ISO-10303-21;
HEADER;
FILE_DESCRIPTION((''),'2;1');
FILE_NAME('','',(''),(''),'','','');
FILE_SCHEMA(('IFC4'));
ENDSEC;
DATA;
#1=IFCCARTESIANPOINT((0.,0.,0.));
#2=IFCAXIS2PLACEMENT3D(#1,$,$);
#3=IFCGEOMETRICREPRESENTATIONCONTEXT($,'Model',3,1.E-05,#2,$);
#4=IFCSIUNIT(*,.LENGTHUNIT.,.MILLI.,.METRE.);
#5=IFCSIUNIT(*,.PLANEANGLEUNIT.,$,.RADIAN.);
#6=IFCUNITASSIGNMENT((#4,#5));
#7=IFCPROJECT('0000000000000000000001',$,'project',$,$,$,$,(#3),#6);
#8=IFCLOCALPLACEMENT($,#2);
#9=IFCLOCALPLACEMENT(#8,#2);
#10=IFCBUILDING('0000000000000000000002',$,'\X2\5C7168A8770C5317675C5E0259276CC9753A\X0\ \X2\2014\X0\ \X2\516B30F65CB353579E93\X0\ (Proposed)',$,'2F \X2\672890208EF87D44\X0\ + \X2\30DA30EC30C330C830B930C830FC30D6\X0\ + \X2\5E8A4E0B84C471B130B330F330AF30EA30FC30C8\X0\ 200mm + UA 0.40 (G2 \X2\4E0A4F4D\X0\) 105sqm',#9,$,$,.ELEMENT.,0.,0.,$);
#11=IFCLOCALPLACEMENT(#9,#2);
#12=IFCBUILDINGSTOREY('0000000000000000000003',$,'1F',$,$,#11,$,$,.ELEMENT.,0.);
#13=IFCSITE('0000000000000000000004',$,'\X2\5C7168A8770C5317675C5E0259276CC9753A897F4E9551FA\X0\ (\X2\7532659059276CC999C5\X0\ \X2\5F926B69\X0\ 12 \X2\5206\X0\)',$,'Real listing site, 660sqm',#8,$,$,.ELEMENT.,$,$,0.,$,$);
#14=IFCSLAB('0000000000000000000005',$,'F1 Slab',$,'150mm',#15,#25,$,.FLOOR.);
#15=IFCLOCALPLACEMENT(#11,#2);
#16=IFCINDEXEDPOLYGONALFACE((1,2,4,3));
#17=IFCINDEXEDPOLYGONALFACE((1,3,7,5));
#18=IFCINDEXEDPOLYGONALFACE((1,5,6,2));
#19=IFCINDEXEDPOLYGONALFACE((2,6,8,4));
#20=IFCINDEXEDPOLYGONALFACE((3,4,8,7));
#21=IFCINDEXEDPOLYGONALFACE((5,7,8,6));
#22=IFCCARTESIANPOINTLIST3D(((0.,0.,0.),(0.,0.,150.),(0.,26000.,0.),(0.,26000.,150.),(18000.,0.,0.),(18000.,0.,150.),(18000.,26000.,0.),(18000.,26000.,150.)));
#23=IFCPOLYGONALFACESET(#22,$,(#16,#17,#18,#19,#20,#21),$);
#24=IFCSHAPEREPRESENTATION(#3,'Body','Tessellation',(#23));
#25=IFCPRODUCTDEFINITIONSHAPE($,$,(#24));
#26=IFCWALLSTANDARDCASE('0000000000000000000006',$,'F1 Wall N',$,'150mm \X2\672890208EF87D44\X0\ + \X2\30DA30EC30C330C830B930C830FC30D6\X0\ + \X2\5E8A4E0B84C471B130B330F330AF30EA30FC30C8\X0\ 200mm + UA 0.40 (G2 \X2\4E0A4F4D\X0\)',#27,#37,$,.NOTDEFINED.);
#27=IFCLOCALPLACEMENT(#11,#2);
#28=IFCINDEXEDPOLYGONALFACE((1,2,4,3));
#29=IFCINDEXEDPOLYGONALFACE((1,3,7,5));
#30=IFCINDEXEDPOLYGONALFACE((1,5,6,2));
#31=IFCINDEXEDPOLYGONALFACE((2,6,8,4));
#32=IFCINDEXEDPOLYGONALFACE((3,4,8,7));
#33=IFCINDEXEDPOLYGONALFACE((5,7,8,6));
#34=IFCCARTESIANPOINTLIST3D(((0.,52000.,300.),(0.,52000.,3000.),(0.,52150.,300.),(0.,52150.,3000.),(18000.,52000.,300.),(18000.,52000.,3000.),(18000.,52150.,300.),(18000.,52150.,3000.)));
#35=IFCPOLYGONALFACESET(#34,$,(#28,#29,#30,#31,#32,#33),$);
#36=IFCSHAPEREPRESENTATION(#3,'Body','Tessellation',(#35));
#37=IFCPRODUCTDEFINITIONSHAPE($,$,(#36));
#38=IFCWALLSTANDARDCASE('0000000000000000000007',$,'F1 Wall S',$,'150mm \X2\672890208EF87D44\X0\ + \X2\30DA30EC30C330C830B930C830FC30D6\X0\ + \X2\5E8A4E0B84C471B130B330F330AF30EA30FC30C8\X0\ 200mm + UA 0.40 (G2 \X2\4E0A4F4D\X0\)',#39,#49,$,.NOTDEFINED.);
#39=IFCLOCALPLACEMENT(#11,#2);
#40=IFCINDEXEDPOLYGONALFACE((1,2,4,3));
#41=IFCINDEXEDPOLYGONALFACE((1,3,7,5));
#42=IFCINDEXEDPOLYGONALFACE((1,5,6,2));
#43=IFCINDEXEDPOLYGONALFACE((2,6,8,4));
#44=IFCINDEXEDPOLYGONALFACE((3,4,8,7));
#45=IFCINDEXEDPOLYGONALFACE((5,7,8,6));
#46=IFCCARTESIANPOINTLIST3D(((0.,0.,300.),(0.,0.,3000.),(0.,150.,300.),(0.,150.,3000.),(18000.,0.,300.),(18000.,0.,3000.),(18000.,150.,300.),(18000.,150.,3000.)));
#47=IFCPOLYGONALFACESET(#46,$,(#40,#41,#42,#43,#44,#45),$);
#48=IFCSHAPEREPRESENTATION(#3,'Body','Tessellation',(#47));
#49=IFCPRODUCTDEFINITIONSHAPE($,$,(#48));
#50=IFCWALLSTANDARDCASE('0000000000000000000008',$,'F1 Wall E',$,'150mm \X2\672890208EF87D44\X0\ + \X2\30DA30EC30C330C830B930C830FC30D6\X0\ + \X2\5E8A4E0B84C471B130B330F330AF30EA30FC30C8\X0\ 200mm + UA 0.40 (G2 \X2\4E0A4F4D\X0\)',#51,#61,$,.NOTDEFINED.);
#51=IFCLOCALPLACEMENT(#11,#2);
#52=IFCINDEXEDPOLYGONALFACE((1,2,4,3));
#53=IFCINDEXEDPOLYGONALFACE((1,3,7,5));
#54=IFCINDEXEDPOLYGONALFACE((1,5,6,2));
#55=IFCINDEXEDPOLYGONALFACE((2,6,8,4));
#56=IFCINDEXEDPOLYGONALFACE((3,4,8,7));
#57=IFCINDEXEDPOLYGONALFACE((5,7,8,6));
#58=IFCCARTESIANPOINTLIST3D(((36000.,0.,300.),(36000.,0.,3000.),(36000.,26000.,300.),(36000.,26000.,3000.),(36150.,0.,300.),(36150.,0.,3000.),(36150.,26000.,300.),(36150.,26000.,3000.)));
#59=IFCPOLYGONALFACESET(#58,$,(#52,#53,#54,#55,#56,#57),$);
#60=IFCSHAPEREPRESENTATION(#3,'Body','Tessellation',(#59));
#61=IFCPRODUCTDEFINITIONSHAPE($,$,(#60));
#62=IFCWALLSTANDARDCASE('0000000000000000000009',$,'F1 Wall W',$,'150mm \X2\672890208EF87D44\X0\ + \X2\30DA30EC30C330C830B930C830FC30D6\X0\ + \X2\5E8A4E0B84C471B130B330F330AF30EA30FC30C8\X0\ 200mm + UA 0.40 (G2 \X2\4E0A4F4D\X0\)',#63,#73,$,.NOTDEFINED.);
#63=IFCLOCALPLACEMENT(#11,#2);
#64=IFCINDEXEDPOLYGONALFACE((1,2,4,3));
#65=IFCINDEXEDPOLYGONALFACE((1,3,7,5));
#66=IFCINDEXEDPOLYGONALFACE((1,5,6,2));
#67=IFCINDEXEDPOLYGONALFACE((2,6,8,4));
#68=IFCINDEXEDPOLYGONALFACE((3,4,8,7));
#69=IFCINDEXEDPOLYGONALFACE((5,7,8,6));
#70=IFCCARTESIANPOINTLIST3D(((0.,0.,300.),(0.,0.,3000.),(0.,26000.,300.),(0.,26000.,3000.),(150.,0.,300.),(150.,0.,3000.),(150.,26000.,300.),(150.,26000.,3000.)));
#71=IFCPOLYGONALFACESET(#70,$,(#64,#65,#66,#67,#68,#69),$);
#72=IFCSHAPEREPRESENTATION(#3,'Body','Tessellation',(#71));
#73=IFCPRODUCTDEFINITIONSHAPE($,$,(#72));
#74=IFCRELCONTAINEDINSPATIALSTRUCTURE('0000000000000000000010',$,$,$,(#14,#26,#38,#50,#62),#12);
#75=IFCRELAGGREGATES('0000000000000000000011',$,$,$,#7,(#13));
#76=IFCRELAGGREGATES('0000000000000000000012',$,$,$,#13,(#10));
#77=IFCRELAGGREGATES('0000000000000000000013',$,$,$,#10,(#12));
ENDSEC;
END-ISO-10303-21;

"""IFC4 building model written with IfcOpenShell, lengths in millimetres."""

from ifc_helpers import new_model, si_unit, frame, frame_2d, origin, place, context, project, spatial, rectangle, extrude, element, save


model = new_model("IFC4")

# Units and contexts
model_context = context("Model", 3, precision=1e-05, world=origin())
ifc_project = project(units=[si_unit("LENGTHUNIT", "METRE", prefix="MILLI"), si_unit("PLANEANGLEUNIT", "RADIAN")], contexts=[model_context])

# Site, building, storey
site_placement = place(None, origin())
site = spatial("IfcSite", under=ifc_project, at=site_placement, Name="山梨県北杜市大泉町西井出 (甲斐大泉駅 徒歩 12 分)", ObjectType="Real listing site, 660sqm", CompositionType="ELEMENT", RefElevation=0.0)
building_placement = place(site_placement, origin())
building = spatial("IfcBuilding", under=site, at=building_placement, Name="山梨県北杜市大泉町 — 八ヶ岳南麓 (Proposed)", ObjectType="2F 木造軸組 + ペレットストーブ + 床下蓄熱コンクリート 200mm + UA 0.40 (G2 上位) 105sqm", CompositionType="ELEMENT", ElevationOfRefHeight=0.0, ElevationOfTerrain=0.0)
storey_placement = place(building_placement, origin())
storey = spatial("IfcBuildingStorey", under=building, at=storey_placement, Name="1F", CompositionType="ELEMENT", Elevation=0.0)

# Slab
slab_placement = place(storey_placement, origin())
element("IfcSlab", 1, at=slab_placement, inside=storey, Name="F1 Slab", ObjectType="150mm", PredefinedType="FLOOR", context=model_context, shape_type="SweptSolid", body=[
    extrude(rectangle(XDim=18000.0, YDim=26000.0, at=frame_2d((9000.0, 13000.0))), origin(), (0.0, 0.0, 1.0), 150.0),
])

# Walls
wall_1_placement = place(storey_placement, frame((0.0, 26000.0, 150.0)))
element("IfcWallStandardCase", 2, at=wall_1_placement, inside=storey, Name="F1 Wall N", ObjectType="150mm 木造軸組 + ペレットストーブ + 床下蓄熱コンクリート 200mm + UA 0.40 (G2 上位)", PredefinedType="NOTDEFINED", context=model_context, shape_type="SweptSolid", body=[
    extrude(rectangle(XDim=18000.0, YDim=150.0, at=frame_2d((9000.0, 75.0))), frame((0.0, 26000.0, 150.0)), (0.0, 0.0, 1.0), 2700.0),
])
wall_2_placement = place(storey_placement, frame((0.0, 0.0, 150.0)))
element("IfcWallStandardCase", 3, at=wall_2_placement, inside=storey, Name="F1 Wall S", ObjectType="150mm 木造軸組 + ペレットストーブ + 床下蓄熱コンクリート 200mm + UA 0.40 (G2 上位)", PredefinedType="NOTDEFINED", context=model_context, shape_type="SweptSolid", body=[
    extrude(rectangle(XDim=18000.0, YDim=150.0, at=frame_2d((9000.0, 75.0))), frame((0.0, 0.0, 150.0)), (0.0, 0.0, 1.0), 2700.0),
])
wall_3_placement = place(storey_placement, frame((18000.0, 0.0, 150.0)))
element("IfcWallStandardCase", 4, at=wall_3_placement, inside=storey, Name="F1 Wall E", ObjectType="150mm 木造軸組 + ペレットストーブ + 床下蓄熱コンクリート 200mm + UA 0.40 (G2 上位)", PredefinedType="NOTDEFINED", context=model_context, shape_type="SweptSolid", body=[
    extrude(rectangle(XDim=150.0, YDim=26000.0, at=frame_2d((75.0, 13000.0))), frame((18000.0, 0.0, 150.0)), (0.0, 0.0, 1.0), 2700.0),
])
wall_4_placement = place(storey_placement, frame((0.0, 0.0, 150.0)))
element("IfcWallStandardCase", 5, at=wall_4_placement, inside=storey, Name="F1 Wall W", ObjectType="150mm 木造軸組 + ペレットストーブ + 床下蓄熱コンクリート 200mm + UA 0.40 (G2 上位)", PredefinedType="NOTDEFINED", context=model_context, shape_type="SweptSolid", body=[
    extrude(rectangle(XDim=150.0, YDim=26000.0, at=frame_2d((75.0, 13000.0))), frame((0.0, 0.0, 150.0)), (0.0, 0.0, 1.0), 2700.0),
])

save(model, "model.ifc")
